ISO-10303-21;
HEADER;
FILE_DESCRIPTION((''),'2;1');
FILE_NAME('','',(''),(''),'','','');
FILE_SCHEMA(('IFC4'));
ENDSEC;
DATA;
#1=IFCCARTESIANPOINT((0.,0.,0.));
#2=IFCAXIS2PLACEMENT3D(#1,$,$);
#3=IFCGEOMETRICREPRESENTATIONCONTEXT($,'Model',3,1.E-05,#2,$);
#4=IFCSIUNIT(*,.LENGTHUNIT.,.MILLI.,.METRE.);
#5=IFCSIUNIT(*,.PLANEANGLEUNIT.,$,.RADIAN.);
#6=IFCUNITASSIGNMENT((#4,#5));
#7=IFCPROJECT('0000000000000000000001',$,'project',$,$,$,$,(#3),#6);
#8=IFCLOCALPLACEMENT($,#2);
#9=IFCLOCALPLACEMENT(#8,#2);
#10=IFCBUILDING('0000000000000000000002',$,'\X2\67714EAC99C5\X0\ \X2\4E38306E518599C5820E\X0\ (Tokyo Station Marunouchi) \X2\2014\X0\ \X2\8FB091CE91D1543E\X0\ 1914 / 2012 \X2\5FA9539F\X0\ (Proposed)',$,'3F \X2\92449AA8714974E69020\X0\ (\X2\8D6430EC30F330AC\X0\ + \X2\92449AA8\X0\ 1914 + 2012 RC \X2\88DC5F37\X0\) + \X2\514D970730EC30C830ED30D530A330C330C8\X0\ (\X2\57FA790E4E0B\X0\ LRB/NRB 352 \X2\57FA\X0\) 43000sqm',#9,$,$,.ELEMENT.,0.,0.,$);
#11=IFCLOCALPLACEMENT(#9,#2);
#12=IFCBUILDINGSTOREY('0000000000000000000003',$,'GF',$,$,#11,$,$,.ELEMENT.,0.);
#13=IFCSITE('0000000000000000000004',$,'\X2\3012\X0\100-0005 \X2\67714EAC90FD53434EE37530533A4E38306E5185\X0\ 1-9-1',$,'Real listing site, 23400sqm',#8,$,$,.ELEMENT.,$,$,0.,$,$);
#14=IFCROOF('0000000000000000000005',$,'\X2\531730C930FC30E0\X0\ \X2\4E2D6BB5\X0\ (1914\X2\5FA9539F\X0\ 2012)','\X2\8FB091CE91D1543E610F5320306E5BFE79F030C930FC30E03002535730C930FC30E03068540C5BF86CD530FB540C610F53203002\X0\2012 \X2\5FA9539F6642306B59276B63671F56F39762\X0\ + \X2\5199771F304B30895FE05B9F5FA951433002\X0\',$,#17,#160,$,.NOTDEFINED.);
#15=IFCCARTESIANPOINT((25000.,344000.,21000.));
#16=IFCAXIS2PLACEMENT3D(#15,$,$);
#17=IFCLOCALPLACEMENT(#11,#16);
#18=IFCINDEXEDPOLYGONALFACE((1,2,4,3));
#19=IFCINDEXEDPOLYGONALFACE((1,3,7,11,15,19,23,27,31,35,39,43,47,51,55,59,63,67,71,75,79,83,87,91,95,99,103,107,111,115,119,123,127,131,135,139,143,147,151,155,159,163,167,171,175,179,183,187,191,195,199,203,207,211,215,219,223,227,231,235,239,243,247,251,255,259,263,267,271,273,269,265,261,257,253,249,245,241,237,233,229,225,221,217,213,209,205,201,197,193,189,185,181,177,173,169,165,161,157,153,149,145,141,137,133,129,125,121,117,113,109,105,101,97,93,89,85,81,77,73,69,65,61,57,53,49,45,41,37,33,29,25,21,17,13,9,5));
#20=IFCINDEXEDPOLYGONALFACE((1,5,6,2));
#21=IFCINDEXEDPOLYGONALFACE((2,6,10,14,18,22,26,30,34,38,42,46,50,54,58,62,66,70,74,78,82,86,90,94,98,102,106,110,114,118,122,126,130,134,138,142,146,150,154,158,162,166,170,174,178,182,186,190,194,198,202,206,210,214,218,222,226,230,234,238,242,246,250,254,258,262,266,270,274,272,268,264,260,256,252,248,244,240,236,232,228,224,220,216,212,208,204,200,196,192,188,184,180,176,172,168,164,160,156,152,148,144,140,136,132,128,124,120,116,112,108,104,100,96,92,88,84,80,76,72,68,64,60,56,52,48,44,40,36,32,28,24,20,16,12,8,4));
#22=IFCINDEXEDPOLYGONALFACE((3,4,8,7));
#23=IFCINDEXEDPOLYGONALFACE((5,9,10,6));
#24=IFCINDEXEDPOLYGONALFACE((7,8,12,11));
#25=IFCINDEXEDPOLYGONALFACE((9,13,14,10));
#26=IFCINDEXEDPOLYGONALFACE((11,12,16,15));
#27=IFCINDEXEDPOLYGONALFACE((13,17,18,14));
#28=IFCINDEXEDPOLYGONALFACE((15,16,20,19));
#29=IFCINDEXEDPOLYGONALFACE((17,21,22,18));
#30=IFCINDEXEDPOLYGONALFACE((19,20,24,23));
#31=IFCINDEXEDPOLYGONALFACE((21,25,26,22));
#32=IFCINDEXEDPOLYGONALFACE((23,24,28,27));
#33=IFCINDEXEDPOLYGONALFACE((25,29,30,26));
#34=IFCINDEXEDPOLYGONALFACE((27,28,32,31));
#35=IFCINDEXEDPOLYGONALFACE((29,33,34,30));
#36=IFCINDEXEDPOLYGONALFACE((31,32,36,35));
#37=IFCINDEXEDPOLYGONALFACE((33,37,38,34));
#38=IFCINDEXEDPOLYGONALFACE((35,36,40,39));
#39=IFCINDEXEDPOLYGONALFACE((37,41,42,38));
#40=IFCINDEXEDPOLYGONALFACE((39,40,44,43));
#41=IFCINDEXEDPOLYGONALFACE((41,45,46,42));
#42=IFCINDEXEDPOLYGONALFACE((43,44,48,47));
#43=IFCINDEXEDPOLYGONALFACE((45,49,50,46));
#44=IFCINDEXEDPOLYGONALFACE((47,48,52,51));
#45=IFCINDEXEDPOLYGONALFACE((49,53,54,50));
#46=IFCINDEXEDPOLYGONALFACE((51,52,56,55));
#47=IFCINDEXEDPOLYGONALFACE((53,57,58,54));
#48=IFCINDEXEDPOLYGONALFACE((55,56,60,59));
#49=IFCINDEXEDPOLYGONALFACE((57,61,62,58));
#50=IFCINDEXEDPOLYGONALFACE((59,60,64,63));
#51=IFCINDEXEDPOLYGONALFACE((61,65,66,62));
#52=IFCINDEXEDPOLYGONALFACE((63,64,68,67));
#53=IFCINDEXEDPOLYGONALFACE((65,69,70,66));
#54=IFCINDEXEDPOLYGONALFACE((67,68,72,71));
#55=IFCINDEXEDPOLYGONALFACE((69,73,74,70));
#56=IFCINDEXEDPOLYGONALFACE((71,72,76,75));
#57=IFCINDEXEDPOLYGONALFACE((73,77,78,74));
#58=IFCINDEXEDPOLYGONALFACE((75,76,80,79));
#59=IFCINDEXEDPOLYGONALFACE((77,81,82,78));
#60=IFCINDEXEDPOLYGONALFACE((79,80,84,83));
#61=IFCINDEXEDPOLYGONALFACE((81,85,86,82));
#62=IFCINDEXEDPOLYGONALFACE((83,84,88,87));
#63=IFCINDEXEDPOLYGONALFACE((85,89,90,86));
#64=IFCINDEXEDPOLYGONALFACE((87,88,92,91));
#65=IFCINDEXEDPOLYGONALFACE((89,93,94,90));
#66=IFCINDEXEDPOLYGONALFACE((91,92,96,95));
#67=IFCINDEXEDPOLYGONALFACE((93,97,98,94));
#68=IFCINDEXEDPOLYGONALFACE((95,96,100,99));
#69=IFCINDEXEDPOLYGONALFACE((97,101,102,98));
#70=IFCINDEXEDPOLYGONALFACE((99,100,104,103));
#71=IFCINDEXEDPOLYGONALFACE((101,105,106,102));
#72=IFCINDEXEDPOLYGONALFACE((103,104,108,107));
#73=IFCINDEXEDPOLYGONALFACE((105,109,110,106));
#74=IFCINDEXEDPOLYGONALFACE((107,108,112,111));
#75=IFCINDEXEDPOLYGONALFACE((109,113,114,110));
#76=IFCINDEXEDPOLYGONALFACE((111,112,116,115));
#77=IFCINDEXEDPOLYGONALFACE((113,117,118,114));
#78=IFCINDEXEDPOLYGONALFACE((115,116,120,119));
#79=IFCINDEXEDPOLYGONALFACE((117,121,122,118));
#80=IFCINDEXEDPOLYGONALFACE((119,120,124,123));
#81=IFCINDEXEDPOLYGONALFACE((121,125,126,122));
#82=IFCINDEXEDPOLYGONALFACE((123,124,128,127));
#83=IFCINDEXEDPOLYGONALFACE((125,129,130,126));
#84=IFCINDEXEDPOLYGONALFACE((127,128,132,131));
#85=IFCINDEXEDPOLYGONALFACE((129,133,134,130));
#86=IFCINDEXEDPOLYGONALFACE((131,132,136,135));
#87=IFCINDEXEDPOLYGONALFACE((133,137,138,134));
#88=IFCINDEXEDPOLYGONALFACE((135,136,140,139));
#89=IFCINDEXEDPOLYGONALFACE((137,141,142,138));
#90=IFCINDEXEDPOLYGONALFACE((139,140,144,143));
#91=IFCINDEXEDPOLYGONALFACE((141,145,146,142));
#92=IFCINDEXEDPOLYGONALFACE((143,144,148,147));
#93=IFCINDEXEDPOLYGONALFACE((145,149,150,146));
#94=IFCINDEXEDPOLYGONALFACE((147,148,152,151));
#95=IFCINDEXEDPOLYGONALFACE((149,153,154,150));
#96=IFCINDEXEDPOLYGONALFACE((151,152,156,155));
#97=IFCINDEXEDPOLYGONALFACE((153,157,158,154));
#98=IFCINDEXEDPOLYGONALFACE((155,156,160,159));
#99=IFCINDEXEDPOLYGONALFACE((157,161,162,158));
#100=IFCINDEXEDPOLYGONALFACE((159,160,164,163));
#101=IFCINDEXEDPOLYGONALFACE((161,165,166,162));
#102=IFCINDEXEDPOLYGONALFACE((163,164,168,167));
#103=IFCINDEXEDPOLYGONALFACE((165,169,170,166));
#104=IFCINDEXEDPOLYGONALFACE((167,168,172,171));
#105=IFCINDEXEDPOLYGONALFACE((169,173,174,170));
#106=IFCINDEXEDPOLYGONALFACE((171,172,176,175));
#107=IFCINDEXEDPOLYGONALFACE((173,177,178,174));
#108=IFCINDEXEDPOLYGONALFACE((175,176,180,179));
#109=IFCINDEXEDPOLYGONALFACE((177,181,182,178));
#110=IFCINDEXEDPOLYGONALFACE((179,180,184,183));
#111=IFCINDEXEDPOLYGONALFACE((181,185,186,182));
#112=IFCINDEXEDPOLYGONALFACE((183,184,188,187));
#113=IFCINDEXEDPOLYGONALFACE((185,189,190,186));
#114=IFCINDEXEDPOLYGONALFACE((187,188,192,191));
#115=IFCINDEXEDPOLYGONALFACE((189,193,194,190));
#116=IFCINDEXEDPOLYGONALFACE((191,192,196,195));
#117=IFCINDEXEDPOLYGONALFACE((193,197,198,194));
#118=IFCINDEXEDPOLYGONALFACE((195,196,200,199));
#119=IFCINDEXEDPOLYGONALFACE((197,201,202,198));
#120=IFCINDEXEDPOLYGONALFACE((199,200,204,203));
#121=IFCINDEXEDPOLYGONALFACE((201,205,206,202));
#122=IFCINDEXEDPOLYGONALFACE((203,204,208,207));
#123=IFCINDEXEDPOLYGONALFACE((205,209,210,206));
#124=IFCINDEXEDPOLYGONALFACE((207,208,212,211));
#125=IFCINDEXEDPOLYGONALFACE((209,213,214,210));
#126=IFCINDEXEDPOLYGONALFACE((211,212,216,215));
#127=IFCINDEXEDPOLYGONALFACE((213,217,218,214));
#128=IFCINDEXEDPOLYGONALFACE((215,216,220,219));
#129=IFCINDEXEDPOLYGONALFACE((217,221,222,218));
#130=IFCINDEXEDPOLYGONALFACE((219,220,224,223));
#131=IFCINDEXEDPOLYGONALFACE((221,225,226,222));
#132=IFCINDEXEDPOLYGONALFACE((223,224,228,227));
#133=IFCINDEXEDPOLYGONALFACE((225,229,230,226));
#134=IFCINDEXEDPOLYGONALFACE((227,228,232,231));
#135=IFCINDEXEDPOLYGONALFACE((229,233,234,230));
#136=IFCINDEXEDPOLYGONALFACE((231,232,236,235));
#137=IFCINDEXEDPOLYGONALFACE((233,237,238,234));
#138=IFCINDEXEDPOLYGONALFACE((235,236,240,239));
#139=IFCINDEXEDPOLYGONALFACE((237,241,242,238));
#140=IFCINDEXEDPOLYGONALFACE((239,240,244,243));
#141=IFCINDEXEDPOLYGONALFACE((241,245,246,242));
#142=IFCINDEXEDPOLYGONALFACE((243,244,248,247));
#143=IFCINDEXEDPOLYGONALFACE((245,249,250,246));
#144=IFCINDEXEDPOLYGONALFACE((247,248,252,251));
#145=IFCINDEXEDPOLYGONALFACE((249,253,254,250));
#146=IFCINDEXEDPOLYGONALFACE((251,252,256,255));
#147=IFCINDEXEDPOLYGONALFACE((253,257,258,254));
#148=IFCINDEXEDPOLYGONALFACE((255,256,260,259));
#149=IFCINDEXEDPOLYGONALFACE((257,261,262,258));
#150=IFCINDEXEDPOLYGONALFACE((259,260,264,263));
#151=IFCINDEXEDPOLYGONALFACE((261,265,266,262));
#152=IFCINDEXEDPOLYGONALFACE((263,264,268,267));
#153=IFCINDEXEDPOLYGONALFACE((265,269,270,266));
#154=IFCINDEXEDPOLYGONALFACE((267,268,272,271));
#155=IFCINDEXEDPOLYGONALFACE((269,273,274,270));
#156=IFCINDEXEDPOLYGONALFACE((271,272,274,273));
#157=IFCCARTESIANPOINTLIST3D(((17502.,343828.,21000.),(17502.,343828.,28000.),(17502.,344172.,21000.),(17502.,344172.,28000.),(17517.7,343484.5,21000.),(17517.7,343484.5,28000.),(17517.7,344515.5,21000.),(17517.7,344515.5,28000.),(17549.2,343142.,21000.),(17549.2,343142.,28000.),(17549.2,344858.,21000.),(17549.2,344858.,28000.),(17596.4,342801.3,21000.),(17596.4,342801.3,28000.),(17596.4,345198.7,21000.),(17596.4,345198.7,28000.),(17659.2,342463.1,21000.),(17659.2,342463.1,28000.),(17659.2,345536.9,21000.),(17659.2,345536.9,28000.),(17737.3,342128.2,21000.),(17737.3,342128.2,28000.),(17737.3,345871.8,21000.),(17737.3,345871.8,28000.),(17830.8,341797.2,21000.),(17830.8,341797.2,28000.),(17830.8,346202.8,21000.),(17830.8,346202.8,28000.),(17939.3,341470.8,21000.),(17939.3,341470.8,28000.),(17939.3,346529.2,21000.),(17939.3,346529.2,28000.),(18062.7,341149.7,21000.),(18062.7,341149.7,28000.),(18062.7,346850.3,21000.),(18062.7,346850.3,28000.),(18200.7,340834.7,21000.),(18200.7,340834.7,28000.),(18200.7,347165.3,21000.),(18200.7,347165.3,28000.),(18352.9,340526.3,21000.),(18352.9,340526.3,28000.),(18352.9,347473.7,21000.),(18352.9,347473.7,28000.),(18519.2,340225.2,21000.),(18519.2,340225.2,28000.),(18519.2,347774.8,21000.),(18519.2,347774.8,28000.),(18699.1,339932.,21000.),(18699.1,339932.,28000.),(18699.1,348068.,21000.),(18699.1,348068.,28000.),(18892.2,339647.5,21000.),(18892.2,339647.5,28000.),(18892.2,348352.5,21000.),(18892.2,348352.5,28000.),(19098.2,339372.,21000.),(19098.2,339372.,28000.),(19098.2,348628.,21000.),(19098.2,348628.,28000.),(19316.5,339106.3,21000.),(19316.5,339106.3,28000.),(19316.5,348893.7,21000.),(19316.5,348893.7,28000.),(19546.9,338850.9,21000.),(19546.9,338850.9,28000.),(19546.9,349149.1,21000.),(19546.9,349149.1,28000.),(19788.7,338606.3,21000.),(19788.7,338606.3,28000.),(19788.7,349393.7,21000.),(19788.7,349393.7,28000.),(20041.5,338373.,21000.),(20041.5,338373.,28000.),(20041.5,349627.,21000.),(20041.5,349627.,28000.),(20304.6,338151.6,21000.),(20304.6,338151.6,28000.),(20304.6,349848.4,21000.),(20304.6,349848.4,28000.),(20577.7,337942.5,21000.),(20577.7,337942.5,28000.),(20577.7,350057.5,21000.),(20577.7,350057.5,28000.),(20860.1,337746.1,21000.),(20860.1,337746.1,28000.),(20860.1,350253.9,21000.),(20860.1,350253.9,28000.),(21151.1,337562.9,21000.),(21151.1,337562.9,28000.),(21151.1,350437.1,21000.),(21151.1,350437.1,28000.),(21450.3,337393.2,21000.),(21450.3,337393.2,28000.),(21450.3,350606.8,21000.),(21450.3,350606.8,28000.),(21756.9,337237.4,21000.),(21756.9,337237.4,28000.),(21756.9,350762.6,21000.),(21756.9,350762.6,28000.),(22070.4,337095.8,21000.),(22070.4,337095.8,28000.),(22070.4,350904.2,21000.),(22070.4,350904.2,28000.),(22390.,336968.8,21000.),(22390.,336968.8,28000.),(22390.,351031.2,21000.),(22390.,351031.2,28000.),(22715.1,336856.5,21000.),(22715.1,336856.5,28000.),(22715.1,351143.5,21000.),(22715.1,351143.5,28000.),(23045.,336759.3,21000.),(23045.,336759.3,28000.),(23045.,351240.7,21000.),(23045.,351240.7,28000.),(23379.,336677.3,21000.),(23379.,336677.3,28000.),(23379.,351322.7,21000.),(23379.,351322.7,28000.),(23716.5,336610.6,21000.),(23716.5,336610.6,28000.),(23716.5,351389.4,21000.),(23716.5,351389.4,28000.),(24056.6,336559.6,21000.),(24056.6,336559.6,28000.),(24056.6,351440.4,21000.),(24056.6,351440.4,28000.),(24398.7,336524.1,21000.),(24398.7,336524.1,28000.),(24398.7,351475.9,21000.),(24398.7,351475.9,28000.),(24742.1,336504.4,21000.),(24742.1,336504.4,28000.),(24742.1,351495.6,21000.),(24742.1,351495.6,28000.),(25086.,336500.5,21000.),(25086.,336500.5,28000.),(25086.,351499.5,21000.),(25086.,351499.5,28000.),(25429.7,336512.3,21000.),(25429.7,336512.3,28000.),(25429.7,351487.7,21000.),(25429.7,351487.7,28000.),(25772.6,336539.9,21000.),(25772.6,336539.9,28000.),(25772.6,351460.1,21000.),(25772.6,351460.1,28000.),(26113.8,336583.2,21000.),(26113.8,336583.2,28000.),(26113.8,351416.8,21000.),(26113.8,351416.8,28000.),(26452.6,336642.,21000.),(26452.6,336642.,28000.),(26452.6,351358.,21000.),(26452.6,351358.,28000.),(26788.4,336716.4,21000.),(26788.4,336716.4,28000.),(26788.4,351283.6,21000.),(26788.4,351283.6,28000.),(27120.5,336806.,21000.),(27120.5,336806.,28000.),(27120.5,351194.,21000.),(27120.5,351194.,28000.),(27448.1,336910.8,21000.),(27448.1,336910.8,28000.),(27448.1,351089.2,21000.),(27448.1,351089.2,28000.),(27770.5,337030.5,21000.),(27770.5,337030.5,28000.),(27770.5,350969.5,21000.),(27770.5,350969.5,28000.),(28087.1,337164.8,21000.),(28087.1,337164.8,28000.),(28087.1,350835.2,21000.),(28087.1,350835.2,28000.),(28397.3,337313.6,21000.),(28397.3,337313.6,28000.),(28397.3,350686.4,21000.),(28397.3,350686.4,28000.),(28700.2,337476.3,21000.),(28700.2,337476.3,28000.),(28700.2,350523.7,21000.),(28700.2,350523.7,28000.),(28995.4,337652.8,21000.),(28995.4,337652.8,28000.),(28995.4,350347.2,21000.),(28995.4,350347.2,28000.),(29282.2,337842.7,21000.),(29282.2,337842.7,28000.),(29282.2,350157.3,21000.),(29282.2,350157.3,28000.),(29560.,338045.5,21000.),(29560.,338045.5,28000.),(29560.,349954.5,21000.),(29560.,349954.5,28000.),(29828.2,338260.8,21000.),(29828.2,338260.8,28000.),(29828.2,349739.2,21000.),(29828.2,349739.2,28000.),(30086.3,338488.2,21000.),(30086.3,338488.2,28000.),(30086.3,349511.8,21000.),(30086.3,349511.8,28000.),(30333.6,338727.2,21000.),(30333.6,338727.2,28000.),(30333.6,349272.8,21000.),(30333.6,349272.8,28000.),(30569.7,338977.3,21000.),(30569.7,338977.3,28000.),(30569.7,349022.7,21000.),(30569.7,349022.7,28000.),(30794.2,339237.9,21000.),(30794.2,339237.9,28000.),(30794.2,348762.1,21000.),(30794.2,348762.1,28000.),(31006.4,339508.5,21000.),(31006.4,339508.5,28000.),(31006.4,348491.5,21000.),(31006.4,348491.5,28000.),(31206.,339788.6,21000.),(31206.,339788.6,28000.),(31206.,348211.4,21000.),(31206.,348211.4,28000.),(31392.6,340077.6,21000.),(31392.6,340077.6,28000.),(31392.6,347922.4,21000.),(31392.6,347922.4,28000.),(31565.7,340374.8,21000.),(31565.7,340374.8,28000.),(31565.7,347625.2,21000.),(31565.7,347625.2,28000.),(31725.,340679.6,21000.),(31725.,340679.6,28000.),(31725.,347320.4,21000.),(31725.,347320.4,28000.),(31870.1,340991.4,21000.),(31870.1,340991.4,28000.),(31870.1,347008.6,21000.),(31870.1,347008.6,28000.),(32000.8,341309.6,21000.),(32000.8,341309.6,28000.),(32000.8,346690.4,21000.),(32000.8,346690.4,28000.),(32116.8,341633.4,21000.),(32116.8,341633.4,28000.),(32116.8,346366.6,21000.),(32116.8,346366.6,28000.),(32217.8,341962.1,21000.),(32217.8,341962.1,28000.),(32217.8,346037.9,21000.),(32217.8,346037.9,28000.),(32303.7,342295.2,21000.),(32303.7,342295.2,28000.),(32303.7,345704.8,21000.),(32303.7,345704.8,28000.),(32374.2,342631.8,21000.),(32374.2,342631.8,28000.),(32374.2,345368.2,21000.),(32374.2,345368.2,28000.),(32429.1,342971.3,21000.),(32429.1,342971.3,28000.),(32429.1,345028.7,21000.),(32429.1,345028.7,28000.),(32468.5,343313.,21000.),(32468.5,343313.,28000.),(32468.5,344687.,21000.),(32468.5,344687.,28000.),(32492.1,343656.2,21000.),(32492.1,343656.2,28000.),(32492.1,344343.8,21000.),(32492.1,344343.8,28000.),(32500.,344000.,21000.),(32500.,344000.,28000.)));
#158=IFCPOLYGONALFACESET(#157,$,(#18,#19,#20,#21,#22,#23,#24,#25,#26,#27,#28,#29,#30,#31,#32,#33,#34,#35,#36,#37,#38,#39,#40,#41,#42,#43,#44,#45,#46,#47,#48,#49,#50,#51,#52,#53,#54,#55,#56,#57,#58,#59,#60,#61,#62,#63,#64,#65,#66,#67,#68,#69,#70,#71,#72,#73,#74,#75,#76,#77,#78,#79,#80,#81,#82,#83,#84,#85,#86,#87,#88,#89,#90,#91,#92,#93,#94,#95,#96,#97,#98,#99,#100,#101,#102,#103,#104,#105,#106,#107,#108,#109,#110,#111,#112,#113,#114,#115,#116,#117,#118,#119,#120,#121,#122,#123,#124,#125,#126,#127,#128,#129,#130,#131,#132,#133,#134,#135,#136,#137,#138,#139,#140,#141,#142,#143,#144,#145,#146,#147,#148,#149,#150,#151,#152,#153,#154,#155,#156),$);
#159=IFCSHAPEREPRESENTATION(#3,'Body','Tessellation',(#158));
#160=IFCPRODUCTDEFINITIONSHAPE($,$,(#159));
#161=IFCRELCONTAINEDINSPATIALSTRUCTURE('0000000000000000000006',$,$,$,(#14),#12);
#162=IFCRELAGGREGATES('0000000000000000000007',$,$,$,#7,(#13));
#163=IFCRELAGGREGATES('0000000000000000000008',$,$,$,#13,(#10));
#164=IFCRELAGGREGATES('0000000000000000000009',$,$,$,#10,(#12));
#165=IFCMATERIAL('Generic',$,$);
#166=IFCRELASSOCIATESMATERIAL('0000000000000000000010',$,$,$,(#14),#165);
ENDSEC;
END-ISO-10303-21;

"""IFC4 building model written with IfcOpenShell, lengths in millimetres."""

from ifc_helpers import new_model, si_unit, frame, origin, origin_2d, place, context, project, spatial, circle, extrude, material, element, save


model = new_model("IFC4")

# Units and contexts
model_context = context("Model", 3, precision=1e-05, world=origin())
ifc_project = project(units=[si_unit("LENGTHUNIT", "METRE", prefix="MILLI"), si_unit("PLANEANGLEUNIT", "RADIAN")], contexts=[model_context])

# Site, building, storey
site_placement = place(None, origin())
site = spatial("IfcSite", under=ifc_project, at=site_placement, Name="〒100-0005 東京都千代田区丸の内 1-9-1", ObjectType="Real listing site, 23400sqm", CompositionType="ELEMENT", RefElevation=0.0)
building_placement = place(site_placement, origin())
building = spatial("IfcBuilding", under=site, at=building_placement, Name="東京駅 丸の内駅舎 (Tokyo Station Marunouchi) — 辰野金吾 1914 / 2012 復原 (Proposed)", ObjectType="3F 鉄骨煉瓦造 (赤レンガ + 鉄骨 1914 + 2012 RC 補強) + 免震レトロフィット (基礎下 LRB/NRB 352 基) 43000sqm", CompositionType="ELEMENT", ElevationOfRefHeight=0.0, ElevationOfTerrain=0.0)
storey_placement = place(building_placement, origin())
storey = spatial("IfcBuildingStorey", under=building, at=storey_placement, Name="GF", CompositionType="ELEMENT", Elevation=0.0)

# Shared definitions
ifc_material_1 = material(Name="Generic")

# Roof
roof_1_placement = place(storey_placement, frame((25000.0, 344000.0, 21000.0)))
element("IfcRoof", 1, at=roof_1_placement, inside=storey, material=ifc_material_1, Name="北ドーム 中段 (1914復原 2012)", Description="辰野金吾意匠の対称ドーム。南ドームと同寸法・同意匠。2012 復原時に大正期図面 + 写真から忠実復元。", PredefinedType="NOTDEFINED", context=model_context, shape_type="SweptSolid", body=[
    extrude(circle(Radius=7500.0, at=origin_2d()), frame((25000.0, 344000.0, 21000.0)), (0.0, 0.0, 1.0), 7000.0),
])

save(model, "model.ifc")
